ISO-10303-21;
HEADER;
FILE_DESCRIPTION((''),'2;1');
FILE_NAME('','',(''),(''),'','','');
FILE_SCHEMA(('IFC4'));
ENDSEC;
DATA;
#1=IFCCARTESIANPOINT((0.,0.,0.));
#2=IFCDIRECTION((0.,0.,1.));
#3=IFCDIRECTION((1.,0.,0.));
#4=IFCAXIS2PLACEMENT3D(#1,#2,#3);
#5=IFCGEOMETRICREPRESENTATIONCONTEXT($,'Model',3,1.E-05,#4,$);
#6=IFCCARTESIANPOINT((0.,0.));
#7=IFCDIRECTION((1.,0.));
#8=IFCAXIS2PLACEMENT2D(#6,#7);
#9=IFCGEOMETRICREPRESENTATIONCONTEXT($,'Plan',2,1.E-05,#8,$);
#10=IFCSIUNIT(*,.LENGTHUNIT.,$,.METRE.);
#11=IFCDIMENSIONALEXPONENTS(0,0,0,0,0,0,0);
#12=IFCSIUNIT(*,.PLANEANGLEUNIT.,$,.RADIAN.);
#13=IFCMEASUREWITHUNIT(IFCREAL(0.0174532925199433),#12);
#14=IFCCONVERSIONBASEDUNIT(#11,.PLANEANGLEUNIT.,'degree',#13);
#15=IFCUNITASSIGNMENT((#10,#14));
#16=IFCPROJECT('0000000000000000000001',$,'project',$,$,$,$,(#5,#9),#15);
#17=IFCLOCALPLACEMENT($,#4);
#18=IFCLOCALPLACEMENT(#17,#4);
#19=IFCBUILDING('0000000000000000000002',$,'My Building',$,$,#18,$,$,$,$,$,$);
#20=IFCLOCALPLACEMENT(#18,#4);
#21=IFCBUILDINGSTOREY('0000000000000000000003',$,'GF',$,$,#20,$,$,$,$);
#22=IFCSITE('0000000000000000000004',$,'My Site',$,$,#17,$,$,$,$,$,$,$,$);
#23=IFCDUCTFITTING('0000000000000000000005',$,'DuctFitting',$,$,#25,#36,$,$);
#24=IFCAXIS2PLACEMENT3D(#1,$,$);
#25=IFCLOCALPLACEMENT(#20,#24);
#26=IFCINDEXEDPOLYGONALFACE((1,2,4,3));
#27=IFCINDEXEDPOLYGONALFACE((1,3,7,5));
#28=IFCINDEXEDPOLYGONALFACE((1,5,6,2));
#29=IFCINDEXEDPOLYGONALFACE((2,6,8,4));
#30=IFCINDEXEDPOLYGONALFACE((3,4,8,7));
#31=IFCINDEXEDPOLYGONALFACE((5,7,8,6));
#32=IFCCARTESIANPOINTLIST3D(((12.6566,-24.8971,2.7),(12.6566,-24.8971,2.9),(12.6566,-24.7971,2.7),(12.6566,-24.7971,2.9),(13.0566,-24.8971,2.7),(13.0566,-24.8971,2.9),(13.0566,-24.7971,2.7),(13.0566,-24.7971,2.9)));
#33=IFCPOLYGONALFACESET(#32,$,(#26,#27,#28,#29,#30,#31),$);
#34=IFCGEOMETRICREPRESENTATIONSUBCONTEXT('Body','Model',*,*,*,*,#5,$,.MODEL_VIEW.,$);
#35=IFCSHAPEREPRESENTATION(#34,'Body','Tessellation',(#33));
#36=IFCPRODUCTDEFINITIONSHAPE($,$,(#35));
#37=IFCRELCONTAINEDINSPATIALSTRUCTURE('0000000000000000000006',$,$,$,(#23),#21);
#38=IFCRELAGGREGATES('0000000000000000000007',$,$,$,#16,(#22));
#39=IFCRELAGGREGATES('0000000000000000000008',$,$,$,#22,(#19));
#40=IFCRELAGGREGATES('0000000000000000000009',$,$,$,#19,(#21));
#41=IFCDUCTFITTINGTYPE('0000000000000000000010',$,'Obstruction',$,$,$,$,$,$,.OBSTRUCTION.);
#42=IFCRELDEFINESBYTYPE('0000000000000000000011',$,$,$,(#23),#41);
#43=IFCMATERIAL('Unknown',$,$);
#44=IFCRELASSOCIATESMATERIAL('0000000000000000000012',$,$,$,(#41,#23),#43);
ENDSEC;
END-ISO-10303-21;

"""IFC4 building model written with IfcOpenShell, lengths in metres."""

from ifc_helpers import new_model, entity, si_unit, converted_unit, frame, origin_with_axes, origin_2d_with_axis, place, context, subcontext, project, spatial, rectangle, extrude, material, material_profile, profile_set, profile_usage, type_object, element, save


model = new_model("IFC4")

# Units and contexts
model_context = context("Model", 3, precision=1e-05, world=origin_with_axes())
plan_context = context("Plan", 2, precision=1e-05, world=origin_2d_with_axis())
body_context_1 = subcontext(model_context, "Body", "Model", "MODEL_VIEW")
ifc_project = project(units=[si_unit("LENGTHUNIT", "METRE"), converted_unit("PLANEANGLEUNIT", "degree", entity("IfcReal", 0.0174532925199433), si_unit("PLANEANGLEUNIT", "RADIAN"), dimensions=[0, 0, 0, 0, 0, 0, 0])], contexts=[model_context, plan_context])

# Site, building, storey
site_placement = place(None, origin_with_axes())
site = spatial("IfcSite", under=ifc_project, at=site_placement, Name="My Site")
building_placement = place(site_placement, origin_with_axes())
building = spatial("IfcBuilding", under=site, at=building_placement, Name="My Building")
storey_placement = place(building_placement, origin_with_axes())
storey = spatial("IfcBuildingStorey", under=building, at=storey_placement, Name="GF")

# Shared definitions
ifc_material = material(Name="Unknown")

# Duct fitting
ifc_material_profile_1 = material_profile(ifc_material, rectangle(XDim=0.4, YDim=0.2))
ifc_profile_set_1 = profile_set([ifc_material_profile_1])
duct_fitting_type_1 = type_object("IfcDuctFittingType", Name="Obstruction", PredefinedType="OBSTRUCTION", material=ifc_profile_set_1)
ifc_profile_usage_1 = profile_usage(ifc_profile_set_1, cardinal=5)
duct_fitting_1_placement = place(storey_placement, frame((12.8566, -24.7971, 2.8), z_axis=(0.0, -1.0, 0.0), x_axis=(1.0, 0.0, 0.0)))
element("IfcDuctFitting", 1, at=duct_fitting_1_placement, inside=storey, type_object=duct_fitting_type_1, material=ifc_profile_usage_1, Name="DuctFitting", context=body_context_1, shape_type="SweptSolid", body=[
    extrude(rectangle(XDim=0.4, YDim=0.2), origin_with_axes(), (0.0, 0.0, 1.0), 0.1),
])

save(model, "model.ifc")
